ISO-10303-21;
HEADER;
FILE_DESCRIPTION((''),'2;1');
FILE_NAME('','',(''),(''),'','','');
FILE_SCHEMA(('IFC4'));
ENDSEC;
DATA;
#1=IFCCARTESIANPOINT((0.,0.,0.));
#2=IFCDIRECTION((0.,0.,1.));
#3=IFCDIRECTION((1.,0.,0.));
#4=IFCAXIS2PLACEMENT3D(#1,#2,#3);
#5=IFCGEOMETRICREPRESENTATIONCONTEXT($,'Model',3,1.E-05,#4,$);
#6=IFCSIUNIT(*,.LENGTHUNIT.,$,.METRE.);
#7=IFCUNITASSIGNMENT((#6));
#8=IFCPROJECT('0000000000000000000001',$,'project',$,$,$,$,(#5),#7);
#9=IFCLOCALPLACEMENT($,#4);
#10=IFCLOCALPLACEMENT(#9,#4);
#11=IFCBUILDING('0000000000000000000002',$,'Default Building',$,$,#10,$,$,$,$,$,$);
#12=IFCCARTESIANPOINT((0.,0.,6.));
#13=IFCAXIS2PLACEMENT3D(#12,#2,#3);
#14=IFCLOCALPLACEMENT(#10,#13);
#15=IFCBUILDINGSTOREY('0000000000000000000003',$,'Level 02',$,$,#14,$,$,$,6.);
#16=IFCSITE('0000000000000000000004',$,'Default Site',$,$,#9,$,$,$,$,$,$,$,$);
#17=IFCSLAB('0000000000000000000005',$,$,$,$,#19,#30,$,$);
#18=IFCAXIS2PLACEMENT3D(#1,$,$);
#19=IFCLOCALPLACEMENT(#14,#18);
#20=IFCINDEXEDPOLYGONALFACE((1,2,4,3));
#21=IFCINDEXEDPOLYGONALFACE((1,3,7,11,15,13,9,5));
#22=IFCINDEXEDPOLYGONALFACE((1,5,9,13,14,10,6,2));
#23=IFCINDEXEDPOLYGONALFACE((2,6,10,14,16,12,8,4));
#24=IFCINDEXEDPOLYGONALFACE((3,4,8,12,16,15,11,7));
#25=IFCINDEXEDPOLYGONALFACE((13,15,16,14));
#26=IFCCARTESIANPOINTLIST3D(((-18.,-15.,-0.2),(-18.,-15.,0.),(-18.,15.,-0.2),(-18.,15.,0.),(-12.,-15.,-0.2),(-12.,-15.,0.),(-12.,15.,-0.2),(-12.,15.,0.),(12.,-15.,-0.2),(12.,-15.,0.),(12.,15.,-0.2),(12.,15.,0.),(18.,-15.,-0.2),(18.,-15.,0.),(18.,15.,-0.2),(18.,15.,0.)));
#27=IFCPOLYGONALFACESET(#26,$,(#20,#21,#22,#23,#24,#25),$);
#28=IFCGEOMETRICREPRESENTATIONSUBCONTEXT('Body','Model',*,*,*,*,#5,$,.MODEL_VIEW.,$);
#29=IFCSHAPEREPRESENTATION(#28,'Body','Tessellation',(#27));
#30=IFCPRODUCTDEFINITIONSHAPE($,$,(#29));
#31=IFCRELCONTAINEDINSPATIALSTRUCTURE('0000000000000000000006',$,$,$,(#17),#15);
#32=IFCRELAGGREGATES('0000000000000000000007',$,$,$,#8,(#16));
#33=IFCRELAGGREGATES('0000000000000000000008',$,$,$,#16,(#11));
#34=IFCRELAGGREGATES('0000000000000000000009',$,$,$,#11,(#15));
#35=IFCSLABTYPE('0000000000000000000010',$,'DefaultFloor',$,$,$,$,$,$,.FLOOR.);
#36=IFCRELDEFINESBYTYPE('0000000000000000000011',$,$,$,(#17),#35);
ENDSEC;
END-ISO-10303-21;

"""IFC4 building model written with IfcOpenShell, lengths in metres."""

from ifc_helpers import new_model, si_unit, frame, origin_with_axes, place, context, subcontext, project, spatial, polyline, outline, extrude, type_object, element, save


model = new_model("IFC4")

# Units and contexts
model_context = context("Model", 3, precision=1e-05, world=origin_with_axes())
body_context = subcontext(model_context, "Body", "Model", "MODEL_VIEW")
ifc_project = project(units=[si_unit("LENGTHUNIT", "METRE")], contexts=[model_context])

# Site, building, storey
site_placement = place(None, origin_with_axes())
site = spatial("IfcSite", under=ifc_project, at=site_placement, Name="Default Site")
building_placement = place(site_placement, origin_with_axes())
building = spatial("IfcBuilding", under=site, at=building_placement, Name="Default Building")
storey_placement = place(building_placement, frame((0.0, 0.0, 6.0), z_axis=(0.0, 0.0, 1.0), x_axis=(1.0, 0.0, 0.0)))
storey = spatial("IfcBuildingStorey", under=building, at=storey_placement, Name="Level 02", Elevation=6.0)

# Slab
slab_type = type_object("IfcSlabType", Name="DefaultFloor", PredefinedType="FLOOR")
slab_placement = place(storey_placement, frame((0.0, 0.0, -6.0), z_axis=(0.0, 0.0, 1.0), x_axis=(1.0, 0.0, 0.0)))
element("IfcSlab", 1, at=slab_placement, inside=storey, type_object=slab_type, context=body_context, shape_type="SweptSolid", body=[
    extrude(outline(polyline([(-18.0, -15.0), (-18.0, 15.0), (-12.0, 15.0), (12.0, 15.0), (18.0, 15.0), (18.0, -15.0), (12.0, -15.0), (-12.0, -15.0), (-18.0, -15.0)])), frame((0.0, 0.0, 6.0), z_axis=(0.0, 0.0, 1.0), x_axis=(1.0, 0.0, 0.0)), (0.0, 0.0, -1.0), 0.2),
])

save(model, "model.ifc")
